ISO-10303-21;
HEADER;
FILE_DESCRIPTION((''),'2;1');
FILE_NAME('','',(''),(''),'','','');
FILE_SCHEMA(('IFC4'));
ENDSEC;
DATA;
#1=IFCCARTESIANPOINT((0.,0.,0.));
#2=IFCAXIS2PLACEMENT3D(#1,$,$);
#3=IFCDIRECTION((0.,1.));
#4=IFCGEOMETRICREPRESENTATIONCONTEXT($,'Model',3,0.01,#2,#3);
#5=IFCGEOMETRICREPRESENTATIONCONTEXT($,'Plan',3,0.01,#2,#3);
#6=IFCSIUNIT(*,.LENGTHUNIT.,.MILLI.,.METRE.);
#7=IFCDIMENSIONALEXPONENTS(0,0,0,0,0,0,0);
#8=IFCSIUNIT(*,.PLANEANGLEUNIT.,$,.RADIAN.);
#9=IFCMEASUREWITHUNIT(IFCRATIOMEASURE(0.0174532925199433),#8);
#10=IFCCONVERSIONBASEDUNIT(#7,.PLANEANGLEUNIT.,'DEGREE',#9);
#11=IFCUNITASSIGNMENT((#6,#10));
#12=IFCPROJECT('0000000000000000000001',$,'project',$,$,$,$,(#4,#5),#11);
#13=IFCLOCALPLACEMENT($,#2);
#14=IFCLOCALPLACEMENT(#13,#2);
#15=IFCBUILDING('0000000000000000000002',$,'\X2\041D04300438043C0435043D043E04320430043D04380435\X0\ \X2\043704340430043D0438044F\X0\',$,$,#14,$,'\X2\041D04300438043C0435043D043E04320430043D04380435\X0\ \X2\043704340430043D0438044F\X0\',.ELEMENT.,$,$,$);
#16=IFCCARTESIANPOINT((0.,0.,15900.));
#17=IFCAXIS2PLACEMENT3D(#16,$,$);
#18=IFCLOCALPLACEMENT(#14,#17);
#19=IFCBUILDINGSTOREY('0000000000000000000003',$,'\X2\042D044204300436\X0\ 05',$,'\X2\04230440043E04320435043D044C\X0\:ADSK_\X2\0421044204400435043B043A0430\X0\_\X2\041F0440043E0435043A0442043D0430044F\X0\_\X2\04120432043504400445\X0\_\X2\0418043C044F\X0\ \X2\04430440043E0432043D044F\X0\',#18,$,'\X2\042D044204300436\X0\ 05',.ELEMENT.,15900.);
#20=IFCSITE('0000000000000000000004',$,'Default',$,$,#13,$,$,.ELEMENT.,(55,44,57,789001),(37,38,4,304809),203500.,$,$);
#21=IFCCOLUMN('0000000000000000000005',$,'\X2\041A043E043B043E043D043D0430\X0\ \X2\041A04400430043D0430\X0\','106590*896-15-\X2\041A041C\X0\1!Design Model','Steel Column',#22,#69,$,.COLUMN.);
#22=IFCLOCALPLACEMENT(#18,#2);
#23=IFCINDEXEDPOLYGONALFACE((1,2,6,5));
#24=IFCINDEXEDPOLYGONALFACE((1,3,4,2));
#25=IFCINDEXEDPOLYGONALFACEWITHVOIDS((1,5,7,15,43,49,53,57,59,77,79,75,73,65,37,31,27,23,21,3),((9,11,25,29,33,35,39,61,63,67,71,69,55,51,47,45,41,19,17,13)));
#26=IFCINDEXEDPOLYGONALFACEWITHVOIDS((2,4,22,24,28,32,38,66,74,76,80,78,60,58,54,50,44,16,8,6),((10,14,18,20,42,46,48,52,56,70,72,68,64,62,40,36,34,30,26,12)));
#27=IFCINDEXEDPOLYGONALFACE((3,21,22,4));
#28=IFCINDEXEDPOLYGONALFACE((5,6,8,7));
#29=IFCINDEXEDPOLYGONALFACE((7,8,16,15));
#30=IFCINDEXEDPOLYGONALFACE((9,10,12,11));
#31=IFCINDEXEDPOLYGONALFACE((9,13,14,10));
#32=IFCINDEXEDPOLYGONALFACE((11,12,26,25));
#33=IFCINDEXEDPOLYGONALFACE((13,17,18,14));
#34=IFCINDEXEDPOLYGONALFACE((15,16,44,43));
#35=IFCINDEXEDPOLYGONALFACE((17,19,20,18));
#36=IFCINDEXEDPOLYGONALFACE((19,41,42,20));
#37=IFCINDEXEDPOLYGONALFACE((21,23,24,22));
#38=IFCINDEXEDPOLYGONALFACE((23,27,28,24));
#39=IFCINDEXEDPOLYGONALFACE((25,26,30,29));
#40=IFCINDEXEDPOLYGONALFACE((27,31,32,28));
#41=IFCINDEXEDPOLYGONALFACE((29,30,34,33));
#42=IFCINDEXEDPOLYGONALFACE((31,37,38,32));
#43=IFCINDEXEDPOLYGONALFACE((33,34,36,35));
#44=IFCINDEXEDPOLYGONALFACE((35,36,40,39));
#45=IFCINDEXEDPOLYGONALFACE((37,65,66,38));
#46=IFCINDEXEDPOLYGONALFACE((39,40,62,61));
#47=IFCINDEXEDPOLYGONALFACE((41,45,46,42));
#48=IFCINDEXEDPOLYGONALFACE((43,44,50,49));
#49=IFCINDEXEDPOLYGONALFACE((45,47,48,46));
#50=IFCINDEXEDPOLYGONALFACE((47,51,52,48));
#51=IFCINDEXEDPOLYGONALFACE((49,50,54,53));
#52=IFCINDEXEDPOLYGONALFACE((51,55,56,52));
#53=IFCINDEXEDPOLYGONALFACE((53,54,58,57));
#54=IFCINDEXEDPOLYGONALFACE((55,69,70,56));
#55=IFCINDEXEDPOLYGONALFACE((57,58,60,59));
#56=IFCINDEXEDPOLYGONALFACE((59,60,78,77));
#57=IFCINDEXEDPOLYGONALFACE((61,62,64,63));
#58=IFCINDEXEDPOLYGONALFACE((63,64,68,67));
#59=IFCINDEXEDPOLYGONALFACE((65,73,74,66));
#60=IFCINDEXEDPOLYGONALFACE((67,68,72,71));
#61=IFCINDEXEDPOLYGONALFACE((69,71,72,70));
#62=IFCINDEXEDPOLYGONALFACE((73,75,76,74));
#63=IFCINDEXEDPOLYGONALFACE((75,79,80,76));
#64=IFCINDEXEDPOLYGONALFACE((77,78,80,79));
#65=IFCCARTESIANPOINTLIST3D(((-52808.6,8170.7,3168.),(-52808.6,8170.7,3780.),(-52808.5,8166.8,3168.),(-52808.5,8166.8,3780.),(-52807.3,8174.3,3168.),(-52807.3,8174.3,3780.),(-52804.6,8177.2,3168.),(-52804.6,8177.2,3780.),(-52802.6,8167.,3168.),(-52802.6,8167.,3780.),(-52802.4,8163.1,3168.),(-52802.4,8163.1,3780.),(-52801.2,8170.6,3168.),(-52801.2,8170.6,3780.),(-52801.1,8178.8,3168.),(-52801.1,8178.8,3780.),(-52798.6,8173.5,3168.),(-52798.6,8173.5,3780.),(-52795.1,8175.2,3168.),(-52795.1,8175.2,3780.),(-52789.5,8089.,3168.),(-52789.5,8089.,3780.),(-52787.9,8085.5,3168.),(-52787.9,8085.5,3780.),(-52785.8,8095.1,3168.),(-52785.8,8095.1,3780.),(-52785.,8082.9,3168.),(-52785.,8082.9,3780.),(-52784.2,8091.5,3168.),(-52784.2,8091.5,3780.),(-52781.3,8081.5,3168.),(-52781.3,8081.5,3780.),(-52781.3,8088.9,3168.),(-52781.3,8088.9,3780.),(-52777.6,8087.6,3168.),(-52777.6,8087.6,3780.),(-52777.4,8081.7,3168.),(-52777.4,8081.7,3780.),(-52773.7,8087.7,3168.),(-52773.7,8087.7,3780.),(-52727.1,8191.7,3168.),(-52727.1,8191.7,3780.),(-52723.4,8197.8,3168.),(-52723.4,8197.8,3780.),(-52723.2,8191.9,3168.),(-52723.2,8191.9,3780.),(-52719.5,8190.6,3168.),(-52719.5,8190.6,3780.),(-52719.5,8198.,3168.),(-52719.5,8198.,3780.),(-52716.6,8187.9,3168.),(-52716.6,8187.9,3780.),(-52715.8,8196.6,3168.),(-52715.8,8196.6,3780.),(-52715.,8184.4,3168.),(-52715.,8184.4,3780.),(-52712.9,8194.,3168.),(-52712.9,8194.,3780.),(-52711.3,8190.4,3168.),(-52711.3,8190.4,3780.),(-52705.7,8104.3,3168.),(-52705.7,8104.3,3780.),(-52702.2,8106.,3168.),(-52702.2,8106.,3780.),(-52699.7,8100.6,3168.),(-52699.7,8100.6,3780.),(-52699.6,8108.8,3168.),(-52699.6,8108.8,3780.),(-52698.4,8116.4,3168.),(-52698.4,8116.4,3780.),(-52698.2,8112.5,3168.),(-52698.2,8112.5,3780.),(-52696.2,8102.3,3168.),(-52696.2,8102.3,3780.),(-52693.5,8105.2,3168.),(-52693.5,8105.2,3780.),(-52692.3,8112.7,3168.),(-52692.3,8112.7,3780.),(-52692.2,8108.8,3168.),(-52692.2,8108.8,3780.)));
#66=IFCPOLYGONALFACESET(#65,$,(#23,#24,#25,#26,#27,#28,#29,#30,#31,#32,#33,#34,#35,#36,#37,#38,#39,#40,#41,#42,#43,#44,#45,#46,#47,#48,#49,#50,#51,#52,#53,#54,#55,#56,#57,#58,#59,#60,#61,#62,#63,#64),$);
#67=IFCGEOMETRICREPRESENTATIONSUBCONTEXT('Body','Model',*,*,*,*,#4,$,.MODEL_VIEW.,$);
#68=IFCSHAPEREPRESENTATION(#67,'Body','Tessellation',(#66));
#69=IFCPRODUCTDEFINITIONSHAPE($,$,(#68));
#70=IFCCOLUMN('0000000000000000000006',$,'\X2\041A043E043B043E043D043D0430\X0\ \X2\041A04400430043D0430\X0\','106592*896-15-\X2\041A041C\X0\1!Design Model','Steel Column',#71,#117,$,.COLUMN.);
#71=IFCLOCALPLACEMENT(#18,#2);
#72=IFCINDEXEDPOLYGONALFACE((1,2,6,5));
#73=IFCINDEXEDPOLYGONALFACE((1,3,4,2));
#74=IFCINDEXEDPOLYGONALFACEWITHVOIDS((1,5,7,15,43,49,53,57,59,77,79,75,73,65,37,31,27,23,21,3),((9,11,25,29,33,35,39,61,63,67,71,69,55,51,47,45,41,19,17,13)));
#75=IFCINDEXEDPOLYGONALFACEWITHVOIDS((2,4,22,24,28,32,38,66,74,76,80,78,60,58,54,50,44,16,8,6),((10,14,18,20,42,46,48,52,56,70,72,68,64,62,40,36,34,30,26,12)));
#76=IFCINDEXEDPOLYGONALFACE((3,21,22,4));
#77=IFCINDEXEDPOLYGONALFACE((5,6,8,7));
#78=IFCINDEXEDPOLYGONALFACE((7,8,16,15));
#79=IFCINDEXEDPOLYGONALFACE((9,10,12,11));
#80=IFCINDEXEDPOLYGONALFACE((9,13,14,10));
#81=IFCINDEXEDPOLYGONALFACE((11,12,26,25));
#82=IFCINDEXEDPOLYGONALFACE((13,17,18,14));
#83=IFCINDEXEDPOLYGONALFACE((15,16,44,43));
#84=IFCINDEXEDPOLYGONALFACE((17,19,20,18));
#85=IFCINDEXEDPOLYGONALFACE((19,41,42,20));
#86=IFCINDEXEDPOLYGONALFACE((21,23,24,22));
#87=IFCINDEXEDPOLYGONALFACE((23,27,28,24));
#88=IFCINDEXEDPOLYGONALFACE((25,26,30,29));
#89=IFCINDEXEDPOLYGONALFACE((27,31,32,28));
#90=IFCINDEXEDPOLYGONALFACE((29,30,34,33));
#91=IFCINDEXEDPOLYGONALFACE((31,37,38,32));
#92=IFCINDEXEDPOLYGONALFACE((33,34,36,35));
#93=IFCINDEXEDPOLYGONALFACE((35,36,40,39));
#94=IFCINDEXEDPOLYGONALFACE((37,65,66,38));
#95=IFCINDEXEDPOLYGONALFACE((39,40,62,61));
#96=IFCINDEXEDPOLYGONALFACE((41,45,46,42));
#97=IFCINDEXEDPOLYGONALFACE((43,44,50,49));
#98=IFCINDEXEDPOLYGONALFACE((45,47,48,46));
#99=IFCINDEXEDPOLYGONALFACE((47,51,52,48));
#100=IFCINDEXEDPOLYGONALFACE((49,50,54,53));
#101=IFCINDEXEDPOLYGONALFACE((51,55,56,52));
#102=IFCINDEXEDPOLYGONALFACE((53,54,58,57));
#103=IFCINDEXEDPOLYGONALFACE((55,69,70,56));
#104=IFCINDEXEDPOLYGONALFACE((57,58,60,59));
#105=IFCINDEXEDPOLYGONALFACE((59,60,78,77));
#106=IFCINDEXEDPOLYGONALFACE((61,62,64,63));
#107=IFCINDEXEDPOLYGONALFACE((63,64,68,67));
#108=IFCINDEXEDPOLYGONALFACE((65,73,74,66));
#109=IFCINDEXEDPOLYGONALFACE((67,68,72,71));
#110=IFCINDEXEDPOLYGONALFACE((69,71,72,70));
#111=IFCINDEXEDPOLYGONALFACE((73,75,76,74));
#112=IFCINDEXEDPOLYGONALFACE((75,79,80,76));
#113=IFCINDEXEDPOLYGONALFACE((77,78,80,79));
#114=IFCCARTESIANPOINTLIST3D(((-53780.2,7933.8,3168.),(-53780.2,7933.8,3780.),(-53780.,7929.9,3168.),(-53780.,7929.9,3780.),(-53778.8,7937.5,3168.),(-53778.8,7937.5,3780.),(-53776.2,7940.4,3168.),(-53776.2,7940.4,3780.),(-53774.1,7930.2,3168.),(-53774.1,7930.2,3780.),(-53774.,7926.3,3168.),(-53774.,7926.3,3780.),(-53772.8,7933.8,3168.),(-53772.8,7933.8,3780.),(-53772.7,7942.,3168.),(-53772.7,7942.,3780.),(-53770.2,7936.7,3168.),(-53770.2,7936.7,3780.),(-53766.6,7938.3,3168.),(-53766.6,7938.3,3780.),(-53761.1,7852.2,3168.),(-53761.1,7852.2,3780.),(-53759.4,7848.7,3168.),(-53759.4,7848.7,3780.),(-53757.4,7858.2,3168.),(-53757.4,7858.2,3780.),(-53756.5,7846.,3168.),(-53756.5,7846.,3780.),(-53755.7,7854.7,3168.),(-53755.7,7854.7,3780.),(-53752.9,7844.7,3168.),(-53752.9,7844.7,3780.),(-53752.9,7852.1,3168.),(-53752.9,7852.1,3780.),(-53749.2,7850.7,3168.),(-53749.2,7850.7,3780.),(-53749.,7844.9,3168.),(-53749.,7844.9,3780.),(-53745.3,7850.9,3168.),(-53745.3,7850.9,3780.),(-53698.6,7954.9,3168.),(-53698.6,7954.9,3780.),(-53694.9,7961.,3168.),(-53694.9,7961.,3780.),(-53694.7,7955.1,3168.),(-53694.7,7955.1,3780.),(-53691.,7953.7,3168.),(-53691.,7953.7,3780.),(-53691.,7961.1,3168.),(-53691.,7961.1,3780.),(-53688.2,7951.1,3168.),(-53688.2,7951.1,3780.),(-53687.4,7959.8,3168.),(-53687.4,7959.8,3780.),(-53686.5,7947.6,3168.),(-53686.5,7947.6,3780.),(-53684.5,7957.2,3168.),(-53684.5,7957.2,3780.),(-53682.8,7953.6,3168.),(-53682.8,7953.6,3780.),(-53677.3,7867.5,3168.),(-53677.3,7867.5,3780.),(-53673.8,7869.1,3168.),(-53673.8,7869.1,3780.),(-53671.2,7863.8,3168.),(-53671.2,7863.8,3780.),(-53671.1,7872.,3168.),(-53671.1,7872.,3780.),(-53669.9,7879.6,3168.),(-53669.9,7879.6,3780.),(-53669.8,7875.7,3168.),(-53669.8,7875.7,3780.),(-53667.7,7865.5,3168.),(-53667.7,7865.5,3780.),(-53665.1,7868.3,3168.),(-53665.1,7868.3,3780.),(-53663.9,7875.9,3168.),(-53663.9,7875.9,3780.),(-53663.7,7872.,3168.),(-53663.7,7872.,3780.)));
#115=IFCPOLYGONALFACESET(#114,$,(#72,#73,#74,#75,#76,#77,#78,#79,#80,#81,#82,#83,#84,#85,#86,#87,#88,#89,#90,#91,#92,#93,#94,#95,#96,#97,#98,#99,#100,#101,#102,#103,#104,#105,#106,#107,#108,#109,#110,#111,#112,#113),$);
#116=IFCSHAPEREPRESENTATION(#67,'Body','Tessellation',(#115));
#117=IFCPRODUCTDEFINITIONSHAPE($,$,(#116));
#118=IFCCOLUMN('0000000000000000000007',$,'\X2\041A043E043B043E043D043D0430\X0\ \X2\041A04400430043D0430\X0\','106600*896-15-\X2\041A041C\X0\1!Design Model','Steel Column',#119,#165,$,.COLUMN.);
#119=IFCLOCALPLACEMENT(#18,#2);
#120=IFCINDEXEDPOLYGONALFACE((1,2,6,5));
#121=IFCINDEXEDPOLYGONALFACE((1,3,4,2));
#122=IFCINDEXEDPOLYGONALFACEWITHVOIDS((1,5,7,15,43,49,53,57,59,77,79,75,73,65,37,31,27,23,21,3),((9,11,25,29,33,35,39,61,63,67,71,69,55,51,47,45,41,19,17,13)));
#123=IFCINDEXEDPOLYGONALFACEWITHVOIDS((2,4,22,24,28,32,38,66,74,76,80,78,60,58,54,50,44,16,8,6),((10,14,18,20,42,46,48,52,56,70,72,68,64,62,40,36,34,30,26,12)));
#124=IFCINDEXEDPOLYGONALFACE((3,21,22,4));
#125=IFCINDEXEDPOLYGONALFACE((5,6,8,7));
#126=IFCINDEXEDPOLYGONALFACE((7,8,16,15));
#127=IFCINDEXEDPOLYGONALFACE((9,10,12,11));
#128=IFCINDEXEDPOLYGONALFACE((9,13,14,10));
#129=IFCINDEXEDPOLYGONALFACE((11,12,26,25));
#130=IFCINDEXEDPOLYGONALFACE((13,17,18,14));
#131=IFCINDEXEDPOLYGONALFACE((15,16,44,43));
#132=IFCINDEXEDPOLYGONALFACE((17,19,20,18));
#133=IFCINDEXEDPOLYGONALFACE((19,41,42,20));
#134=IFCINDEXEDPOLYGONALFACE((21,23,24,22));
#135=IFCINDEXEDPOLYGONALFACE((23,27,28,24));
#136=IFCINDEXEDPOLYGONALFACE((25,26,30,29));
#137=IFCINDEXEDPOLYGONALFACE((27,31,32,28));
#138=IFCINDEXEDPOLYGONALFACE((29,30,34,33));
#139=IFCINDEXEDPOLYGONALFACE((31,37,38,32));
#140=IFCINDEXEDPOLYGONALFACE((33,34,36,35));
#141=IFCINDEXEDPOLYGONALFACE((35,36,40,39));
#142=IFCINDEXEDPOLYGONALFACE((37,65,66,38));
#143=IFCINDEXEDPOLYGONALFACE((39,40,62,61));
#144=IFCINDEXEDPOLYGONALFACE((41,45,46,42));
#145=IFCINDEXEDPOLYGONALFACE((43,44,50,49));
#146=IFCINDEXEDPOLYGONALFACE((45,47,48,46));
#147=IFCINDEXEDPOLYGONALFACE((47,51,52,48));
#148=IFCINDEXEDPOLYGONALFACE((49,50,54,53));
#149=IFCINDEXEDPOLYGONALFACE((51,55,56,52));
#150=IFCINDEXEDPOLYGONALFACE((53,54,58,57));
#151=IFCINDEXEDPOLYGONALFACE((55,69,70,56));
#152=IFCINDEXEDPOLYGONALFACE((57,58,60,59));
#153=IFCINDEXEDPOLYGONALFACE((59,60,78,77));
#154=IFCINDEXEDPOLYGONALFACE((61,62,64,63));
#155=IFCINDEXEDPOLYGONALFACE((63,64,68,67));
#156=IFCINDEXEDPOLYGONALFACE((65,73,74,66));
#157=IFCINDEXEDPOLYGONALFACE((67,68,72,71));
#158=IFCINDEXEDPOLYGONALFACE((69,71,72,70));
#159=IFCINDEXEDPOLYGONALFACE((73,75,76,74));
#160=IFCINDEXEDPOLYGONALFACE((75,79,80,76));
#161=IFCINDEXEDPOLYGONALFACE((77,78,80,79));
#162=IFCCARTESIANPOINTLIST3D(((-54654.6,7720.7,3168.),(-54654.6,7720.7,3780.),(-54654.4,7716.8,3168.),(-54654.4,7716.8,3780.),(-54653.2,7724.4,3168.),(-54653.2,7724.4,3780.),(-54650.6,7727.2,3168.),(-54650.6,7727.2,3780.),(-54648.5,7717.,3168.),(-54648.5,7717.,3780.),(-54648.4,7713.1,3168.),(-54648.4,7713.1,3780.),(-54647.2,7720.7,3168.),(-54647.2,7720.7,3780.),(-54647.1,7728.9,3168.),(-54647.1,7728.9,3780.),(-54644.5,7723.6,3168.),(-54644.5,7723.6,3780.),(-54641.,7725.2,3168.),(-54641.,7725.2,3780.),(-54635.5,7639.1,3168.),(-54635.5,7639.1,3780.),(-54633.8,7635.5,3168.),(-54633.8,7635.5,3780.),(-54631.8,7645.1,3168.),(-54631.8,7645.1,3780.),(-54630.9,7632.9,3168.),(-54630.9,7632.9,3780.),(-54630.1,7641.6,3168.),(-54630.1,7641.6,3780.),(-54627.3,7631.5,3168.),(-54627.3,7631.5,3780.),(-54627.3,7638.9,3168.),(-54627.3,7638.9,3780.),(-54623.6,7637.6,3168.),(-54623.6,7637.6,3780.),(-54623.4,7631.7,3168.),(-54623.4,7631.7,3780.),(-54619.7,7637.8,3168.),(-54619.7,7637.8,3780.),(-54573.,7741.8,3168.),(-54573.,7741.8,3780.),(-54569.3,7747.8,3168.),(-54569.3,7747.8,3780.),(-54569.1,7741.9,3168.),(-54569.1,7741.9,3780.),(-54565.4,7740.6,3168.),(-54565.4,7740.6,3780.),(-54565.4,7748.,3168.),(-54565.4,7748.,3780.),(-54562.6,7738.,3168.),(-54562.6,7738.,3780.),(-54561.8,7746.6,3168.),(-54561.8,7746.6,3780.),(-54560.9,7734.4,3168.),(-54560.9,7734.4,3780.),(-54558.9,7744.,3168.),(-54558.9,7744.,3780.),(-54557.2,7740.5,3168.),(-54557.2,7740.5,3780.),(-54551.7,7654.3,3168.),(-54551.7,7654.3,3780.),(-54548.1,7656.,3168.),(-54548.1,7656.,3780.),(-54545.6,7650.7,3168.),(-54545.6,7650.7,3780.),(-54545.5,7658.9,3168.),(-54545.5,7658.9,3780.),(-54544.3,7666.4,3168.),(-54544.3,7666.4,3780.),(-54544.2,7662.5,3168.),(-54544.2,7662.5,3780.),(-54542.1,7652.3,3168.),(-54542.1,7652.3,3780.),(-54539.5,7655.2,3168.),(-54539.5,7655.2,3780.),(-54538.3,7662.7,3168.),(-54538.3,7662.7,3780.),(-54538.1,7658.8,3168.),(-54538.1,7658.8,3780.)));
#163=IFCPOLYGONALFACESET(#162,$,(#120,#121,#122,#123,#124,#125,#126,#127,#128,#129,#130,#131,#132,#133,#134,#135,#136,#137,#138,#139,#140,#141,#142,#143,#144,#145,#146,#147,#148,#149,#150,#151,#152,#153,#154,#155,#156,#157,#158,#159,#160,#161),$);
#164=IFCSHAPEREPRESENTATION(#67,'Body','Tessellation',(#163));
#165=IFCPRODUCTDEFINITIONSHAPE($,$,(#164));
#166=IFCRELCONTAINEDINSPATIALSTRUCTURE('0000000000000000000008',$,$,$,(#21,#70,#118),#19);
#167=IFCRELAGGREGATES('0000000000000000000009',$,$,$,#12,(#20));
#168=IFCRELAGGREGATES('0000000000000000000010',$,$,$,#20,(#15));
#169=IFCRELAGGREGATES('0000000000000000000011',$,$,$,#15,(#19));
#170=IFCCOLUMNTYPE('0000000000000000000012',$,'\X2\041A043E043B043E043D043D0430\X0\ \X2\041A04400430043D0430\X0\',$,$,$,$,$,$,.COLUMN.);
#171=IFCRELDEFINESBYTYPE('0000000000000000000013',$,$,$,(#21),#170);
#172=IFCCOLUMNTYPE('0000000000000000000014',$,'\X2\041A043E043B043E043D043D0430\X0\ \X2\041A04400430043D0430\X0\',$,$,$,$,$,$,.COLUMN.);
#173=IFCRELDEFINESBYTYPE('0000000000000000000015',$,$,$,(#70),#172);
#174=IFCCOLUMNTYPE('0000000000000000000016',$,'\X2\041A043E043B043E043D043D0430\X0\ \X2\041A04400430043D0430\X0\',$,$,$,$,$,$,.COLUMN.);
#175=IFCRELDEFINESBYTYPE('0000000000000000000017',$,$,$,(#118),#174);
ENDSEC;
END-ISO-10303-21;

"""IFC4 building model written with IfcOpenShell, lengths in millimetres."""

from ifc_helpers import new_model, entity, si_unit, converted_unit, direction, frame, origin, place, context, subcontext, project, spatial, indexed_curve, outline, extrude, type_object, element, save


model = new_model("IFC4")

# Units and contexts
model_context = context("Model", 3, precision=0.01, world=origin(), true_north=direction((0.0, 1.0)))
plan_context = context("Plan", 3, precision=0.01, world=origin(), true_north=direction((0.0, 1.0)))
body_context = subcontext(model_context, "Body", "Model", "MODEL_VIEW")
ifc_project = project(units=[si_unit("LENGTHUNIT", "METRE", prefix="MILLI"), converted_unit("PLANEANGLEUNIT", "DEGREE", entity("IfcRatioMeasure", 0.0174532925199433), si_unit("PLANEANGLEUNIT", "RADIAN"), dimensions=[0, 0, 0, 0, 0, 0, 0])], contexts=[model_context, plan_context])

# Site, building, storey
site_placement = place(None, origin())
site = spatial("IfcSite", under=ifc_project, at=site_placement, Name="Default", CompositionType="ELEMENT", RefLatitude=(55, 44, 57, 789001), RefLongitude=(37, 38, 4, 304809), RefElevation=203500.0)
building_placement = place(site_placement, origin())
building = spatial("IfcBuilding", under=site, at=building_placement, Name="Наименование здания", LongName="Наименование здания", CompositionType="ELEMENT")
storey_placement = place(building_placement, frame((0.0, 0.0, 15900.0)))
storey = spatial("IfcBuildingStorey", under=building, at=storey_placement, Name="Этаж 05", ObjectType="Уровень:ADSK_Стрелка_Проектная_Вверх_Имя уровня", LongName="Этаж 05", CompositionType="ELEMENT", Elevation=15900.0)

# Columns
column_type_1 = type_object("IfcColumnType", Name="Колонна Крана", PredefinedType="COLUMN")
column_1_placement = place(storey_placement, origin())
element("IfcColumn", 1, at=column_1_placement, inside=storey, type_object=column_type_1, Name="Колонна Крана", Description="106590*896-15-КМ1!Design Model", ObjectType="Steel Column", PredefinedType="COLUMN", context=body_context, shape_type="SweptSolid", body=[
    extrude(outline(indexed_curve([(29.5, -56.8), (33.4, -56.8), (37.0, -55.3), (39.7, -52.6), (41.2, -49.0), (56.8, 29.5), (56.8, 33.4), (55.3, 37.0), (52.6, 39.7), (49.0, 41.2), (-29.5, 56.8), (-33.4, 56.8), (-37.0, 55.3), (-39.7, 52.6), (-41.2, 49.0), (-56.8, -29.5), (-56.8, -33.4), (-55.3, -37.0), (-52.6, -39.7), (-49.0, -41.2), (29.5, -56.8)], self_intersect=False), holes=[indexed_curve([(-43.1, -37.3), (-46.7, -35.8), (-49.5, -33.1), (-51.0, -29.5), (-51.0, -25.5), (-37.3, 43.1), (-35.8, 46.7), (-33.1, 49.5), (-29.5, 51.0), (-25.5, 51.0), (43.1, 37.3), (46.7, 35.8), (49.5, 33.1), (51.0, 29.5), (51.0, 25.5), (37.3, -43.1), (35.8, -46.7), (33.1, -49.5), (29.5, -51.0), (25.5, -51.0), (-43.1, -37.3)], self_intersect=False)]), frame((-52750.4, 8139.7, 3168.0), z_axis=(0.0, 0.0, 1.0), x_axis=(0.906681, 0.421816, 0.0)), (0.0, 0.0, 1.0), 612.0),
])
column_type_2 = type_object("IfcColumnType", Name="Колонна Крана", PredefinedType="COLUMN")
column_2_placement = place(storey_placement, origin())
element("IfcColumn", 2, at=column_2_placement, inside=storey, type_object=column_type_2, Name="Колонна Крана", Description="106592*896-15-КМ1!Design Model", ObjectType="Steel Column", PredefinedType="COLUMN", context=body_context, shape_type="SweptSolid", body=[
    extrude(outline(indexed_curve([(29.5, -56.8), (33.4, -56.8), (37.0, -55.3), (39.7, -52.6), (41.2, -49.0), (56.8, 29.5), (56.8, 33.4), (55.3, 37.0), (52.6, 39.7), (49.0, 41.2), (-29.5, 56.8), (-33.4, 56.8), (-37.0, 55.3), (-39.7, 52.6), (-41.2, 49.0), (-56.8, -29.5), (-56.8, -33.4), (-55.3, -37.0), (-52.6, -39.7), (-49.0, -41.2), (29.5, -56.8)], self_intersect=False), holes=[indexed_curve([(-43.1, -37.3), (-46.7, -35.8), (-49.5, -33.1), (-51.0, -29.5), (-51.0, -25.5), (-37.3, 43.1), (-35.8, 46.7), (-33.1, 49.5), (-29.5, 51.0), (-25.5, 51.0), (43.1, 37.3), (46.7, 35.8), (49.5, 33.1), (51.0, 29.5), (51.0, 25.5), (37.3, -43.1), (35.8, -46.7), (33.1, -49.5), (29.5, -51.0), (25.5, -51.0), (-43.1, -37.3)], self_intersect=False)]), frame((-53722.0, 7902.9, 3168.0), z_axis=(0.0, 0.0, 1.0), x_axis=(0.906681, 0.421816, 0.0)), (0.0, 0.0, 1.0), 612.0),
])
column_type_3 = type_object("IfcColumnType", Name="Колонна Крана", PredefinedType="COLUMN")
column_3_placement = place(storey_placement, origin())
element("IfcColumn", 3, at=column_3_placement, inside=storey, type_object=column_type_3, Name="Колонна Крана", Description="106600*896-15-КМ1!Design Model", ObjectType="Steel Column", PredefinedType="COLUMN", context=body_context, shape_type="SweptSolid", body=[
    extrude(outline(indexed_curve([(29.5, -56.8), (33.4, -56.8), (37.0, -55.3), (39.7, -52.6), (41.2, -49.0), (56.8, 29.5), (56.8, 33.4), (55.3, 37.0), (52.6, 39.7), (49.0, 41.2), (-29.5, 56.8), (-33.4, 56.8), (-37.0, 55.3), (-39.7, 52.6), (-41.2, 49.0), (-56.8, -29.5), (-56.8, -33.4), (-55.3, -37.0), (-52.6, -39.7), (-49.0, -41.2), (29.5, -56.8)], self_intersect=False), holes=[indexed_curve([(-43.1, -37.3), (-46.7, -35.8), (-49.5, -33.1), (-51.0, -29.5), (-51.0, -25.5), (-37.3, 43.1), (-35.8, 46.7), (-33.1, 49.5), (-29.5, 51.0), (-25.5, 51.0), (43.1, 37.3), (46.7, 35.8), (49.5, 33.1), (51.0, 29.5), (51.0, 25.5), (37.3, -43.1), (35.8, -46.7), (33.1, -49.5), (29.5, -51.0), (25.5, -51.0), (-43.1, -37.3)], self_intersect=False)]), frame((-54596.3, 7689.8, 3168.0), z_axis=(0.0, 0.0, 1.0), x_axis=(0.906681, 0.421816, 0.0)), (0.0, 0.0, 1.0), 612.0),
])

save(model, "model.ifc")
